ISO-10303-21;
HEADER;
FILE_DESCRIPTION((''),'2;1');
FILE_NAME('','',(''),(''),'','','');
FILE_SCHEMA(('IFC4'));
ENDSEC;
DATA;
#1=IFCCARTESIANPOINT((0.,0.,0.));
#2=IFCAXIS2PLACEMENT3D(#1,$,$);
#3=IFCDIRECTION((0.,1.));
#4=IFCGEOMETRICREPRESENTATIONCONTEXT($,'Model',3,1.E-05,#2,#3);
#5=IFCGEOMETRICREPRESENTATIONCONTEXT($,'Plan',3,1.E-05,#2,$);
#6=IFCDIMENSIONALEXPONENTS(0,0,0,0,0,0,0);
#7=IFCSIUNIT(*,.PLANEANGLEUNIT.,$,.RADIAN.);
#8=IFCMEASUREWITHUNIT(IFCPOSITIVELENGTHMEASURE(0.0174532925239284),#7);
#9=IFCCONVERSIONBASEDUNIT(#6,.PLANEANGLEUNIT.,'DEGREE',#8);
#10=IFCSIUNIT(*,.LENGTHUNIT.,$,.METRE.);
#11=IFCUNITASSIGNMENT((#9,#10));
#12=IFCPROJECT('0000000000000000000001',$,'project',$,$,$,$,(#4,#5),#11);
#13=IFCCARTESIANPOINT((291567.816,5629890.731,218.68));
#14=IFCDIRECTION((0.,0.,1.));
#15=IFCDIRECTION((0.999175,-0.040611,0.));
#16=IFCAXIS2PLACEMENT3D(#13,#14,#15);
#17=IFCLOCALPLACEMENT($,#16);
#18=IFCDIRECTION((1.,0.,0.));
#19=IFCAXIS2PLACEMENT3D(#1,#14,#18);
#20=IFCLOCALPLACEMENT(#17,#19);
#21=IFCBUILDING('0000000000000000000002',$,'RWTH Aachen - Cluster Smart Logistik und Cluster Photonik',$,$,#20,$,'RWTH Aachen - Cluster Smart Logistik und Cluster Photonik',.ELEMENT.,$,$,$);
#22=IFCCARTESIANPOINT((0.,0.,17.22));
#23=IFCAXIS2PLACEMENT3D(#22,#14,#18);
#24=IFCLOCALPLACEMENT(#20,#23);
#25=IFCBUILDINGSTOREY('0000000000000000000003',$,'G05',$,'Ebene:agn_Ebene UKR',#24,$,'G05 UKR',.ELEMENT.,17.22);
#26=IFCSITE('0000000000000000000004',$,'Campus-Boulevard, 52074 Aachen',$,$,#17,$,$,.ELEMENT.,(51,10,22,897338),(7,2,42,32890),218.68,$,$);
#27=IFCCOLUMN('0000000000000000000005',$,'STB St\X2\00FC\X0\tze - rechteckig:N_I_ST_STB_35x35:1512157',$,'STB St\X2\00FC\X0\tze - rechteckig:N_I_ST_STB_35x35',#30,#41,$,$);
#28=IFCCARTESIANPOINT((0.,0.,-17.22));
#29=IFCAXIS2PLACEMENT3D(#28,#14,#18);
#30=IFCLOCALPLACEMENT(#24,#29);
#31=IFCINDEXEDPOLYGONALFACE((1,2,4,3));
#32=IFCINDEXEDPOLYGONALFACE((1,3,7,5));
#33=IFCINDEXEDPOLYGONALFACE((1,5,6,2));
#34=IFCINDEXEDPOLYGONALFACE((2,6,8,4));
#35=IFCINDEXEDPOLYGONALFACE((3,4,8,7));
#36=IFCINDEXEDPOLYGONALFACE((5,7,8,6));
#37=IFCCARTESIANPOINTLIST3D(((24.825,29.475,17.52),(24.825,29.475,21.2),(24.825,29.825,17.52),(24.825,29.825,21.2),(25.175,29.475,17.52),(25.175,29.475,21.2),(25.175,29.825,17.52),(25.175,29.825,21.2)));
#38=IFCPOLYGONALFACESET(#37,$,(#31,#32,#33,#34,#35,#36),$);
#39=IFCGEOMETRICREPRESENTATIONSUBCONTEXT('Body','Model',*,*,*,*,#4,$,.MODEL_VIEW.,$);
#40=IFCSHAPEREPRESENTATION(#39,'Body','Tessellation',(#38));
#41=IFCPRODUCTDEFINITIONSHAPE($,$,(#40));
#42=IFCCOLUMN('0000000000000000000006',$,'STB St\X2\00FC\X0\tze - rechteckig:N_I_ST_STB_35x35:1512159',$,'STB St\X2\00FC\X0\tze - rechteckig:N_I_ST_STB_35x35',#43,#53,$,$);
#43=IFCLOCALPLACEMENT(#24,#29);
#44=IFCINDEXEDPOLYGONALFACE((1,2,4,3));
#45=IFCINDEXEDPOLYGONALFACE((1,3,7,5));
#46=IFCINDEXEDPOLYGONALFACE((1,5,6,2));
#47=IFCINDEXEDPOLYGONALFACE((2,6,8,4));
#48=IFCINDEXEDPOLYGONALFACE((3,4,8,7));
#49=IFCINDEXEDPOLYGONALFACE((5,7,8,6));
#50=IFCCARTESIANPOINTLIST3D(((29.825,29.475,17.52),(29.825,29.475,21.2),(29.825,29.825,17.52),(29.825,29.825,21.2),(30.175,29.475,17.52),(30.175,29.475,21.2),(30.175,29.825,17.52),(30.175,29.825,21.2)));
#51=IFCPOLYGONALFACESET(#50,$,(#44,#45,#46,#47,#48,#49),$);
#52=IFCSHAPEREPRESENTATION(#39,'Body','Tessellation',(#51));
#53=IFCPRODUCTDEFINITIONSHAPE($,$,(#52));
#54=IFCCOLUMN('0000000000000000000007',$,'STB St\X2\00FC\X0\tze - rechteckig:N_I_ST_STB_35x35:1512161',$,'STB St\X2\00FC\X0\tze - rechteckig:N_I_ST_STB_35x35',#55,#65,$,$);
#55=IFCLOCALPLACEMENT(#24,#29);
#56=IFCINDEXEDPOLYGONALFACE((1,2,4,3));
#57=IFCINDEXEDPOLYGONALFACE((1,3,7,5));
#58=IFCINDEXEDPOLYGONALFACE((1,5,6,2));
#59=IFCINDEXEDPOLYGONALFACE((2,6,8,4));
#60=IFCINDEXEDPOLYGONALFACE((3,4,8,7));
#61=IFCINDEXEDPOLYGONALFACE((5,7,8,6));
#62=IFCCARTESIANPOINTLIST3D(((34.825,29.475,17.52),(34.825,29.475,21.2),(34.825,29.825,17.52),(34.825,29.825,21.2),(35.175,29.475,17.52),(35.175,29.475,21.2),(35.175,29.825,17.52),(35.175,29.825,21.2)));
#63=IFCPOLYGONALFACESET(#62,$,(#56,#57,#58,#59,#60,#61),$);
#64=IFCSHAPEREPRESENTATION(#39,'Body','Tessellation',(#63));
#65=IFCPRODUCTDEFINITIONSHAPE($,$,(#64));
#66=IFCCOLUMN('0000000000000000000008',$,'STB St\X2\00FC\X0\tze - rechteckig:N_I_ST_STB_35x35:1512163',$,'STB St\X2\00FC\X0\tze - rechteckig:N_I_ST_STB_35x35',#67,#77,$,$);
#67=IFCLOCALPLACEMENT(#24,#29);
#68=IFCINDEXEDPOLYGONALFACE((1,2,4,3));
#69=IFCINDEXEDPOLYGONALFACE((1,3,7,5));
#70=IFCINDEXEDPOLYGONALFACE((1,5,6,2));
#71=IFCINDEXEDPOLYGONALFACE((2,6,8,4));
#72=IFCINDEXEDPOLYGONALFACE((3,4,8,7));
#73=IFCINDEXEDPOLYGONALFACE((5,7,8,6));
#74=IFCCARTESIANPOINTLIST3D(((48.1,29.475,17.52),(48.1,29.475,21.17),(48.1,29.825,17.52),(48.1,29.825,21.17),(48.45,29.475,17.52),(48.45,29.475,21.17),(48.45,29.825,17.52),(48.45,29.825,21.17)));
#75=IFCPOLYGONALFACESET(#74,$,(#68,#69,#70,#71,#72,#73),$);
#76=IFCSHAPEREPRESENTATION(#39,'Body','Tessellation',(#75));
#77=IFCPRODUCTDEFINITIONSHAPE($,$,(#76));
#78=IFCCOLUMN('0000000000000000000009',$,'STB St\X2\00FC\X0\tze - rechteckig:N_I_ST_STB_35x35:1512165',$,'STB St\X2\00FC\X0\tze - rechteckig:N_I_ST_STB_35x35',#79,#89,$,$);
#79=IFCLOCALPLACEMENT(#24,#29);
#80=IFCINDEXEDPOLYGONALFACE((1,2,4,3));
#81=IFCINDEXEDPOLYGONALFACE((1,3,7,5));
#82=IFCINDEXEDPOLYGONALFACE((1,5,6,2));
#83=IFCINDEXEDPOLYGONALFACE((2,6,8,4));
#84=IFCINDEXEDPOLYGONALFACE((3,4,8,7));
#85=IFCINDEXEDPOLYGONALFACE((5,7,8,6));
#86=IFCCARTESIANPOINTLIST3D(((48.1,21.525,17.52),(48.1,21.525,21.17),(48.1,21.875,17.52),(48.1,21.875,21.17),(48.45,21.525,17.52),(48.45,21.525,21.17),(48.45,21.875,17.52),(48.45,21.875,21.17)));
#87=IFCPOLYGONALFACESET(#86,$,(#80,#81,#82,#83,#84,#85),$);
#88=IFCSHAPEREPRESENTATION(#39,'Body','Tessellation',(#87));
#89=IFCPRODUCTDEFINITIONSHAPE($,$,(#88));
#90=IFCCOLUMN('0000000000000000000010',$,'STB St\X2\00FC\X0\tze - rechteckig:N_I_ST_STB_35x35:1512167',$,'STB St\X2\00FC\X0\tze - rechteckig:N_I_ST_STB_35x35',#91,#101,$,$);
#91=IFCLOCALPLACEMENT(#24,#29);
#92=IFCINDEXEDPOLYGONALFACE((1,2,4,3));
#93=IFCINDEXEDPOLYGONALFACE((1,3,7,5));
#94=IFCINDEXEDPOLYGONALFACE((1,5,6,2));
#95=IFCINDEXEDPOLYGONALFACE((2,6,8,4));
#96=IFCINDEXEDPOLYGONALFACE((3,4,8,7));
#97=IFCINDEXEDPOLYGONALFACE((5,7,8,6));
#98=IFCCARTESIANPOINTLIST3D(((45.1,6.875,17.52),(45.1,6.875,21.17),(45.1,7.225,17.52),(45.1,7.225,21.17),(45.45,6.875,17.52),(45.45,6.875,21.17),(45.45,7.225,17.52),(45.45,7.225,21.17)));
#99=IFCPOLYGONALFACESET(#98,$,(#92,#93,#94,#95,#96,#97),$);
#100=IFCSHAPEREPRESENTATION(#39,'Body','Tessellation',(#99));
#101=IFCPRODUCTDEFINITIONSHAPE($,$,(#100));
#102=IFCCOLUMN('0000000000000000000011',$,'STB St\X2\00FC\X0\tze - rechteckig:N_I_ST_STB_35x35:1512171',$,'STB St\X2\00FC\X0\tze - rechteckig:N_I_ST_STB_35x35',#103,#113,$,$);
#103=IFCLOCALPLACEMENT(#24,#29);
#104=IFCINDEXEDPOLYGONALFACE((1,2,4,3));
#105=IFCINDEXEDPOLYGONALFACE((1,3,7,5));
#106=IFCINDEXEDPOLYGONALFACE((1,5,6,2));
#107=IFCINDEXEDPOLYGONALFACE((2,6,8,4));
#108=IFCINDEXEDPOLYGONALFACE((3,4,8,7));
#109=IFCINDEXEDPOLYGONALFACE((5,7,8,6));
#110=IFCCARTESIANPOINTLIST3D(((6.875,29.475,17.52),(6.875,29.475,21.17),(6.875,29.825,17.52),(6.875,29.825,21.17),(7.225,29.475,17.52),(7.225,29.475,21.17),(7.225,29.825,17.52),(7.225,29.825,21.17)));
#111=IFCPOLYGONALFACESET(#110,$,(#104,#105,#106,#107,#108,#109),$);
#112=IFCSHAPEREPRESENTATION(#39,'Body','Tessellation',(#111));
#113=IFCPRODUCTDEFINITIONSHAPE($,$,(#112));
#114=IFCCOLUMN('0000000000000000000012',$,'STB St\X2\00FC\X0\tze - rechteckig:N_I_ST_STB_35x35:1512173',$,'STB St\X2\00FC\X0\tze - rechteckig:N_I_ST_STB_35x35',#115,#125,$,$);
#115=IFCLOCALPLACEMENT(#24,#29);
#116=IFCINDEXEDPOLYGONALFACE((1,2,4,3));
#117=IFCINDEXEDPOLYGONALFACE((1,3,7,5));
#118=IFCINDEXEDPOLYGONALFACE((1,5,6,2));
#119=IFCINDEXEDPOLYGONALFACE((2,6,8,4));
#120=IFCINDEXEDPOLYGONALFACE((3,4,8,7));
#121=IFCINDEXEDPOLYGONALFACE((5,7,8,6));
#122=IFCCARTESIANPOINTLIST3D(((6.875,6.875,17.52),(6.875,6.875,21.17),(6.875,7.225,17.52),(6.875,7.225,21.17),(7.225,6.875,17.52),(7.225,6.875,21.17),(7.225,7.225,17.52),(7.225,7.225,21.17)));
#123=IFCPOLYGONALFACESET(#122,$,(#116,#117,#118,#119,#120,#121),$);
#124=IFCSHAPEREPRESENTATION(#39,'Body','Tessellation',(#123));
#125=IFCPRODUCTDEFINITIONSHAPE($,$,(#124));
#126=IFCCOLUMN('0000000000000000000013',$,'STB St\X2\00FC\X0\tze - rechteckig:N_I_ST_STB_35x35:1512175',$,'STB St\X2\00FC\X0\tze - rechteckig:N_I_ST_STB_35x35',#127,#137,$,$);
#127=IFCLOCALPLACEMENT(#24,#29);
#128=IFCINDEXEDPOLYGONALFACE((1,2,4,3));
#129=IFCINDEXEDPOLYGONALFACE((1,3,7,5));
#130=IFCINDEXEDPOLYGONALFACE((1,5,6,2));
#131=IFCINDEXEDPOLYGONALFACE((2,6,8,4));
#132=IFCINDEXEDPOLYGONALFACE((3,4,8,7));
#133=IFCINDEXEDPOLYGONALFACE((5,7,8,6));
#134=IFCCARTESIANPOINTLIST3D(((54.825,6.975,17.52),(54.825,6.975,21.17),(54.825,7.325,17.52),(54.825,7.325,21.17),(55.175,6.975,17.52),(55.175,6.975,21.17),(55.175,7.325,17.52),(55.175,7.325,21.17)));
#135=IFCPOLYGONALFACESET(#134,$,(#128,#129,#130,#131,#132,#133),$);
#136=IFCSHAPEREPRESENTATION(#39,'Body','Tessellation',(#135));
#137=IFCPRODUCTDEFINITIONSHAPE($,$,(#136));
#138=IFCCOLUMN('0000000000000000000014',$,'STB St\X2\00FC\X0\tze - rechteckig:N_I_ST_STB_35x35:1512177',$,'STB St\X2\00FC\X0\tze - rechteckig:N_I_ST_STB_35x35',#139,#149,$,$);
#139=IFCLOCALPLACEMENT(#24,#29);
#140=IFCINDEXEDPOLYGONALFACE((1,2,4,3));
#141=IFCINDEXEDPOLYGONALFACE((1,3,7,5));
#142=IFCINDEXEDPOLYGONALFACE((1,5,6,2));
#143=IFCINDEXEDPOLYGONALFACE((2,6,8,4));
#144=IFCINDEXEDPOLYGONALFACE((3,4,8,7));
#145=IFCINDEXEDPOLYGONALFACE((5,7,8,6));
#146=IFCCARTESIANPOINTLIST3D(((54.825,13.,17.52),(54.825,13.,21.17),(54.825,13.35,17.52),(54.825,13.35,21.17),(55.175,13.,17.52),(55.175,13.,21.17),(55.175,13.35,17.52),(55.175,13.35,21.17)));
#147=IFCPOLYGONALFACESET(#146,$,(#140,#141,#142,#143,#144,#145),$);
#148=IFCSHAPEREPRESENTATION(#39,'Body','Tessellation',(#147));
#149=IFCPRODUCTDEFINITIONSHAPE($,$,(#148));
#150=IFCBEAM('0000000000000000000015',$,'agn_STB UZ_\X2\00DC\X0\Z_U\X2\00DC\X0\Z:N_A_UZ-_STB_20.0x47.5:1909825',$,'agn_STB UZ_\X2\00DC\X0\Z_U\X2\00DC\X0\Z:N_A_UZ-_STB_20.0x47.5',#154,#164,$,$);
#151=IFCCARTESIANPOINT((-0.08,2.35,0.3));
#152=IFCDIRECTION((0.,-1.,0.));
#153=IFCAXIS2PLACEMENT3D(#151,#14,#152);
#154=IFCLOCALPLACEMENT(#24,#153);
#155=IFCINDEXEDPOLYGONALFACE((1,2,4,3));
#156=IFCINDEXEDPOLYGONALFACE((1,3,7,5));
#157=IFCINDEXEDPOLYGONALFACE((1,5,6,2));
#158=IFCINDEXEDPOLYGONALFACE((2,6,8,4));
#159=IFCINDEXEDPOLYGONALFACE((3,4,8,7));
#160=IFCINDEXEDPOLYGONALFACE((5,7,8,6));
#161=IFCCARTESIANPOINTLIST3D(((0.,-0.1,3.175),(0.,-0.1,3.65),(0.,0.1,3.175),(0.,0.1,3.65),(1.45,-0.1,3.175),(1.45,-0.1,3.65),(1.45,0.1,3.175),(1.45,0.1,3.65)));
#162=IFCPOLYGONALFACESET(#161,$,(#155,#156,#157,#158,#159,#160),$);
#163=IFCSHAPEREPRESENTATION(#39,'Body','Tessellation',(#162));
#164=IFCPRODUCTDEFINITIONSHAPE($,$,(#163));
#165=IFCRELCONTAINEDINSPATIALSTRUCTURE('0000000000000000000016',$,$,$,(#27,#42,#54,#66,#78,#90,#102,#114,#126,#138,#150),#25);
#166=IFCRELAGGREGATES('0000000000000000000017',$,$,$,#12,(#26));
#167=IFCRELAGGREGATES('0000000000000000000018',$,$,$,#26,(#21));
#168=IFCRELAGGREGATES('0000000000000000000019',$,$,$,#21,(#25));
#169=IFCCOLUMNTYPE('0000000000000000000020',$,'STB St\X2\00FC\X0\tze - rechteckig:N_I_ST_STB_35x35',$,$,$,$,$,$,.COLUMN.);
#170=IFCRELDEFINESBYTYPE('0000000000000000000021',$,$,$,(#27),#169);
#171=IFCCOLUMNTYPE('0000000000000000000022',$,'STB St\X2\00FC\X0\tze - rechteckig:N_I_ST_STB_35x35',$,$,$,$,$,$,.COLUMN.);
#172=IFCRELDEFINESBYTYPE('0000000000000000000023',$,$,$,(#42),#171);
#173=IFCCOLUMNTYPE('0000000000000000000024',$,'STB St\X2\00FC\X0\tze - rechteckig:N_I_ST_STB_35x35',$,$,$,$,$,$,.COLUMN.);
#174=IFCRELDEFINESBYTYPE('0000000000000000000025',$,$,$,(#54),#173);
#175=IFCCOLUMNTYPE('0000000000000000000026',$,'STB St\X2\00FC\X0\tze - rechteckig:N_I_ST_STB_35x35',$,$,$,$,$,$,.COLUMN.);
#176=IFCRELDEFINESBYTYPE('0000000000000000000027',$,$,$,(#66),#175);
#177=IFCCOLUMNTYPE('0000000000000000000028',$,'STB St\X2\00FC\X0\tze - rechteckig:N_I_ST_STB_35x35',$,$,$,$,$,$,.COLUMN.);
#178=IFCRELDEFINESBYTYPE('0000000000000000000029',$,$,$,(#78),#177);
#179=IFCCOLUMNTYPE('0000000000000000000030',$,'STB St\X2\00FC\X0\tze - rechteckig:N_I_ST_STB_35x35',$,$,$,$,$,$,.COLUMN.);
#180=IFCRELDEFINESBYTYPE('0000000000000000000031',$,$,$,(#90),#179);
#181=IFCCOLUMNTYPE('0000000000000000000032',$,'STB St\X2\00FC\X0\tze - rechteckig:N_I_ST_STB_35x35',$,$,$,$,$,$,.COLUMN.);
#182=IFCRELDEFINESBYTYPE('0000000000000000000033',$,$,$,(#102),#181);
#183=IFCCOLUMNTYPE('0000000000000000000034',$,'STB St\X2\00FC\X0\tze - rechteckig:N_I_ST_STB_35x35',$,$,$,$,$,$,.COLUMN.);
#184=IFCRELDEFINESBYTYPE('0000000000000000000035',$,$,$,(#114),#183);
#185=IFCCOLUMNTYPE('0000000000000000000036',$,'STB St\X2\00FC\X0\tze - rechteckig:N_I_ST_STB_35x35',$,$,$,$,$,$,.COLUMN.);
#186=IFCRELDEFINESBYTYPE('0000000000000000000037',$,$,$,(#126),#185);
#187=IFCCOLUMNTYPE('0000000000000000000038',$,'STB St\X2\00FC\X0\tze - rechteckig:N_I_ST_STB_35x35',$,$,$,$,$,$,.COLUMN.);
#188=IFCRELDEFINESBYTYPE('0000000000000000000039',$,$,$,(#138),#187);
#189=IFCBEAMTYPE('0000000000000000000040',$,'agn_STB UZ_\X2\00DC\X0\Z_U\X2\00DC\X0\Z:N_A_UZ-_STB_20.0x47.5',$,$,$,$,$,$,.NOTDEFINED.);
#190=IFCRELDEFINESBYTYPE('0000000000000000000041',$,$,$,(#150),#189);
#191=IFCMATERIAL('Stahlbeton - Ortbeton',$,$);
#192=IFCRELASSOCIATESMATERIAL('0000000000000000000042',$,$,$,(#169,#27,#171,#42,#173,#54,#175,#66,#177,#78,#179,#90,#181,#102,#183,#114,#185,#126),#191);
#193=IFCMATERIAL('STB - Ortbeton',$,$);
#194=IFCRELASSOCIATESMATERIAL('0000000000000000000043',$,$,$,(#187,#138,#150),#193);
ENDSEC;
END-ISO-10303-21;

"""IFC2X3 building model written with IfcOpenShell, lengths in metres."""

from ifc_helpers import new_model, entity, si_unit, converted_unit, direction, frame, frame_2d, origin, origin_with_axes, origin_2d_with_axis, place, context, subcontext, project, spatial, rectangle, extrude, source, transform, mapped, material, type_object, element, save


model = new_model("IFC2X3")

# Units and contexts
model_context = context("Model", 3, precision=1e-05, world=origin(), true_north=direction((0.0, 1.0)))
plan_context = context("Plan", 3, precision=1e-05, world=origin())
body_context = subcontext(model_context, "Body", "Model", "MODEL_VIEW")
ifc_project = project(units=[converted_unit("PLANEANGLEUNIT", "DEGREE", entity("IfcPositiveLengthMeasure", 0.0174532925239284), si_unit("PLANEANGLEUNIT", "RADIAN"), dimensions=[0, 0, 0, 0, 0, 0, 0]), si_unit("LENGTHUNIT", "METRE")], contexts=[model_context, plan_context])

# Site, building, storey
site_placement = place(None, frame((291567.816, 5629890.731, 218.68), z_axis=(0.0, 0.0, 1.0), x_axis=(0.999175, -0.040611, 0.0)))
site = spatial("IfcSite", under=ifc_project, at=site_placement, Name="Campus-Boulevard, 52074 Aachen", CompositionType="ELEMENT", RefLatitude=(51, 10, 22, 897338), RefLongitude=(7, 2, 42, 32890), RefElevation=218.68)
building_placement = place(site_placement, origin_with_axes())
building = spatial("IfcBuilding", under=site, at=building_placement, Name="RWTH Aachen - Cluster Smart Logistik und Cluster Photonik", LongName="RWTH Aachen - Cluster Smart Logistik und Cluster Photonik", CompositionType="ELEMENT")
storey_placement = place(building_placement, frame((0.0, 0.0, 17.22), z_axis=(0.0, 0.0, 1.0), x_axis=(1.0, 0.0, 0.0)))
storey = spatial("IfcBuildingStorey", under=building, at=storey_placement, Name="G05", ObjectType="Ebene:agn_Ebene UKR", LongName="G05 UKR", CompositionType="ELEMENT", Elevation=17.22)

# Columns
ifc_material_1 = material(Name="Stahlbeton - Ortbeton")
column_type_1 = type_object("IfcColumnType", Name="STB Stütze - rechteckig:N_I_ST_STB_35x35", PredefinedType="COLUMN", material=ifc_material_1)
shared_shape_1 = source(origin(), body_context, "Body", "SweptSolid", [
    extrude(rectangle(XDim=0.35, YDim=0.35, at=frame_2d((0.0, 0.0), x_axis=(1.0, 0.0))), frame((25.0, 29.65, 17.52), z_axis=(0.0, 0.0, 1.0), x_axis=(0.0, -1.0, 0.0)), (0.0, 0.0, 1.0), 3.68),
])
column_1_placement = place(storey_placement, frame((0.0, 0.0, -17.22), z_axis=(0.0, 0.0, 1.0), x_axis=(1.0, 0.0, 0.0)))
element("IfcColumn", 1, at=column_1_placement, inside=storey, type_object=column_type_1, material=ifc_material_1, Name="STB Stütze - rechteckig:N_I_ST_STB_35x35:1512157", ObjectType="STB Stütze - rechteckig:N_I_ST_STB_35x35", context=body_context, shape_type="MappedRepresentation", body=[
    mapped(shared_shape_1, transform((0.0, 0.0, 0.0), scale=1.0)),
])
column_type_2 = type_object("IfcColumnType", Name="STB Stütze - rechteckig:N_I_ST_STB_35x35", PredefinedType="COLUMN", material=ifc_material_1)
shared_shape_2 = source(origin(), body_context, "Body", "SweptSolid", [
    extrude(rectangle(XDim=0.35, YDim=0.35, at=frame_2d((0.0, 0.0), x_axis=(1.0, 0.0))), frame((30.0, 29.65, 17.52), z_axis=(0.0, 0.0, 1.0), x_axis=(0.0, -1.0, 0.0)), (0.0, 0.0, 1.0), 3.68),
])
column_2_placement = place(storey_placement, frame((0.0, 0.0, -17.22), z_axis=(0.0, 0.0, 1.0), x_axis=(1.0, 0.0, 0.0)))
element("IfcColumn", 2, at=column_2_placement, inside=storey, type_object=column_type_2, material=ifc_material_1, Name="STB Stütze - rechteckig:N_I_ST_STB_35x35:1512159", ObjectType="STB Stütze - rechteckig:N_I_ST_STB_35x35", context=body_context, shape_type="MappedRepresentation", body=[
    mapped(shared_shape_2, transform((0.0, 0.0, 0.0), scale=1.0)),
])
column_type_3 = type_object("IfcColumnType", Name="STB Stütze - rechteckig:N_I_ST_STB_35x35", PredefinedType="COLUMN", material=ifc_material_1)
shared_shape_3 = source(origin(), body_context, "Body", "SweptSolid", [
    extrude(rectangle(XDim=0.35, YDim=0.35, at=frame_2d((0.0, 0.0), x_axis=(1.0, 0.0))), frame((35.0, 29.65, 17.52), z_axis=(0.0, 0.0, 1.0), x_axis=(0.0, -1.0, 0.0)), (0.0, 0.0, 1.0), 3.68),
])
column_3_placement = place(storey_placement, frame((0.0, 0.0, -17.22), z_axis=(0.0, 0.0, 1.0), x_axis=(1.0, 0.0, 0.0)))
element("IfcColumn", 3, at=column_3_placement, inside=storey, type_object=column_type_3, material=ifc_material_1, Name="STB Stütze - rechteckig:N_I_ST_STB_35x35:1512161", ObjectType="STB Stütze - rechteckig:N_I_ST_STB_35x35", context=body_context, shape_type="MappedRepresentation", body=[
    mapped(shared_shape_3, transform((0.0, 0.0, 0.0), scale=1.0)),
])
column_type_4 = type_object("IfcColumnType", Name="STB Stütze - rechteckig:N_I_ST_STB_35x35", PredefinedType="COLUMN", material=ifc_material_1)
shared_shape_4 = source(origin(), body_context, "Body", "SweptSolid", [
    extrude(rectangle(XDim=0.35, YDim=0.35, at=frame_2d((0.0, 0.0), x_axis=(1.0, 0.0))), frame((48.275, 29.65, 17.52), z_axis=(0.0, 0.0, 1.0), x_axis=(0.0, -1.0, 0.0)), (0.0, 0.0, 1.0), 3.65),
])
column_4_placement = place(storey_placement, frame((0.0, 0.0, -17.22), z_axis=(0.0, 0.0, 1.0), x_axis=(1.0, 0.0, 0.0)))
element("IfcColumn", 4, at=column_4_placement, inside=storey, type_object=column_type_4, material=ifc_material_1, Name="STB Stütze - rechteckig:N_I_ST_STB_35x35:1512163", ObjectType="STB Stütze - rechteckig:N_I_ST_STB_35x35", context=body_context, shape_type="MappedRepresentation", body=[
    mapped(shared_shape_4, transform((0.0, 0.0, 0.0), scale=1.0)),
])
column_type_5 = type_object("IfcColumnType", Name="STB Stütze - rechteckig:N_I_ST_STB_35x35", PredefinedType="COLUMN", material=ifc_material_1)
shared_shape_5 = source(origin(), body_context, "Body", "SweptSolid", [
    extrude(rectangle(XDim=0.35, YDim=0.35, at=origin_2d_with_axis()), frame((48.275, 21.7, 17.52), z_axis=(0.0, 0.0, 1.0), x_axis=(0.0, -1.0, 0.0)), (0.0, 0.0, 1.0), 3.65),
])
column_5_placement = place(storey_placement, frame((0.0, 0.0, -17.22), z_axis=(0.0, 0.0, 1.0), x_axis=(1.0, 0.0, 0.0)))
element("IfcColumn", 5, at=column_5_placement, inside=storey, type_object=column_type_5, material=ifc_material_1, Name="STB Stütze - rechteckig:N_I_ST_STB_35x35:1512165", ObjectType="STB Stütze - rechteckig:N_I_ST_STB_35x35", context=body_context, shape_type="MappedRepresentation", body=[
    mapped(shared_shape_5, transform((0.0, 0.0, 0.0), scale=1.0)),
])
column_type_6 = type_object("IfcColumnType", Name="STB Stütze - rechteckig:N_I_ST_STB_35x35", PredefinedType="COLUMN", material=ifc_material_1)
shared_shape_6 = source(origin(), body_context, "Body", "SweptSolid", [
    extrude(rectangle(XDim=0.35, YDim=0.35, at=frame_2d((0.0, 0.0), x_axis=(1.0, 0.0))), frame((45.275, 7.05, 17.52), z_axis=(0.0, 0.0, 1.0), x_axis=(0.0, -1.0, 0.0)), (0.0, 0.0, 1.0), 3.65),
])
column_6_placement = place(storey_placement, frame((0.0, 0.0, -17.22), z_axis=(0.0, 0.0, 1.0), x_axis=(1.0, 0.0, 0.0)))
element("IfcColumn", 6, at=column_6_placement, inside=storey, type_object=column_type_6, material=ifc_material_1, Name="STB Stütze - rechteckig:N_I_ST_STB_35x35:1512167", ObjectType="STB Stütze - rechteckig:N_I_ST_STB_35x35", context=body_context, shape_type="MappedRepresentation", body=[
    mapped(shared_shape_6, transform((0.0, 0.0, 0.0), scale=1.0)),
])
column_type_7 = type_object("IfcColumnType", Name="STB Stütze - rechteckig:N_I_ST_STB_35x35", PredefinedType="COLUMN", material=ifc_material_1)
shared_shape_7 = source(origin(), body_context, "Body", "SweptSolid", [
    extrude(rectangle(XDim=0.35, YDim=0.35, at=frame_2d((0.0, 0.0), x_axis=(1.0, 0.0))), frame((7.05, 29.65, 17.52), z_axis=(0.0, 0.0, 1.0), x_axis=(0.0, -1.0, 0.0)), (0.0, 0.0, 1.0), 3.65),
])
column_7_placement = place(storey_placement, frame((0.0, 0.0, -17.22), z_axis=(0.0, 0.0, 1.0), x_axis=(1.0, 0.0, 0.0)))
element("IfcColumn", 7, at=column_7_placement, inside=storey, type_object=column_type_7, material=ifc_material_1, Name="STB Stütze - rechteckig:N_I_ST_STB_35x35:1512171", ObjectType="STB Stütze - rechteckig:N_I_ST_STB_35x35", context=body_context, shape_type="MappedRepresentation", body=[
    mapped(shared_shape_7, transform((0.0, 0.0, 0.0), scale=1.0)),
])
column_type_8 = type_object("IfcColumnType", Name="STB Stütze - rechteckig:N_I_ST_STB_35x35", PredefinedType="COLUMN", material=ifc_material_1)
shared_shape_8 = source(origin(), body_context, "Body", "SweptSolid", [
    extrude(rectangle(XDim=0.35, YDim=0.35, at=origin_2d_with_axis()), frame((7.05, 7.05, 17.52), z_axis=(0.0, 0.0, 1.0), x_axis=(0.0, -1.0, 0.0)), (0.0, 0.0, 1.0), 3.65),
])
column_8_placement = place(storey_placement, frame((0.0, 0.0, -17.22), z_axis=(0.0, 0.0, 1.0), x_axis=(1.0, 0.0, 0.0)))
element("IfcColumn", 8, at=column_8_placement, inside=storey, type_object=column_type_8, material=ifc_material_1, Name="STB Stütze - rechteckig:N_I_ST_STB_35x35:1512173", ObjectType="STB Stütze - rechteckig:N_I_ST_STB_35x35", context=body_context, shape_type="MappedRepresentation", body=[
    mapped(shared_shape_8, transform((0.0, 0.0, 0.0), scale=1.0)),
])
column_type_9 = type_object("IfcColumnType", Name="STB Stütze - rechteckig:N_I_ST_STB_35x35", PredefinedType="COLUMN", material=ifc_material_1)
shared_shape_9 = source(origin(), body_context, "Body", "SweptSolid", [
    extrude(rectangle(XDim=0.35, YDim=0.35, at=origin_2d_with_axis()), frame((55.0, 7.15, 17.52), z_axis=(0.0, 0.0, 1.0), x_axis=(0.0, -1.0, 0.0)), (0.0, 0.0, 1.0), 3.65),
])
column_9_placement = place(storey_placement, frame((0.0, 0.0, -17.22), z_axis=(0.0, 0.0, 1.0), x_axis=(1.0, 0.0, 0.0)))
element("IfcColumn", 9, at=column_9_placement, inside=storey, type_object=column_type_9, material=ifc_material_1, Name="STB Stütze - rechteckig:N_I_ST_STB_35x35:1512175", ObjectType="STB Stütze - rechteckig:N_I_ST_STB_35x35", context=body_context, shape_type="MappedRepresentation", body=[
    mapped(shared_shape_9, transform((0.0, 0.0, 0.0), scale=1.0)),
])
ifc_material_2 = material(Name="STB - Ortbeton")
column_type_10 = type_object("IfcColumnType", Name="STB Stütze - rechteckig:N_I_ST_STB_35x35", PredefinedType="COLUMN", material=ifc_material_2)
shared_shape_10 = source(origin(), body_context, "Body", "SweptSolid", [
    extrude(rectangle(XDim=0.35, YDim=0.35, at=frame_2d((0.0, 0.0), x_axis=(1.0, 0.0))), frame((55.0, 13.175, 17.52), z_axis=(0.0, 0.0, 1.0), x_axis=(0.0, -1.0, 0.0)), (0.0, 0.0, 1.0), 3.65),
])
column_10_placement = place(storey_placement, frame((0.0, 0.0, -17.22), z_axis=(0.0, 0.0, 1.0), x_axis=(1.0, 0.0, 0.0)))
element("IfcColumn", 10, at=column_10_placement, inside=storey, type_object=column_type_10, material=ifc_material_2, Name="STB Stütze - rechteckig:N_I_ST_STB_35x35:1512177", ObjectType="STB Stütze - rechteckig:N_I_ST_STB_35x35", context=body_context, shape_type="MappedRepresentation", body=[
    mapped(shared_shape_10, transform((0.0, 0.0, 0.0), scale=1.0)),
])

# Beam
beam_type_1 = type_object("IfcBeamType", Name="agn_STB UZ_ÜZ_UÜZ:N_A_UZ-_STB_20.0x47.5", PredefinedType="NOTDEFINED")
beam_1_placement = place(storey_placement, frame((-0.08, 2.35, 0.3), z_axis=(0.0, 0.0, 1.0), x_axis=(0.0, -1.0, 0.0)))
element("IfcBeam", 11, at=beam_1_placement, inside=storey, type_object=beam_type_1, material=ifc_material_2, Name="agn_STB UZ_ÜZ_UÜZ:N_A_UZ-_STB_20.0x47.5:1909825", ObjectType="agn_STB UZ_ÜZ_UÜZ:N_A_UZ-_STB_20.0x47.5", context=body_context, shape_type="SweptSolid", body=[
    extrude(rectangle(XDim=0.475, YDim=0.2, at=frame_2d((0.0, 0.0), x_axis=(1.0, 0.0))), frame((0.0, 0.0, 3.4125), z_axis=(1.0, 0.0, 0.0), x_axis=(0.0, 0.0, -1.0)), (0.0, 0.0, 1.0), 1.45),
])

save(model, "model.ifc")
